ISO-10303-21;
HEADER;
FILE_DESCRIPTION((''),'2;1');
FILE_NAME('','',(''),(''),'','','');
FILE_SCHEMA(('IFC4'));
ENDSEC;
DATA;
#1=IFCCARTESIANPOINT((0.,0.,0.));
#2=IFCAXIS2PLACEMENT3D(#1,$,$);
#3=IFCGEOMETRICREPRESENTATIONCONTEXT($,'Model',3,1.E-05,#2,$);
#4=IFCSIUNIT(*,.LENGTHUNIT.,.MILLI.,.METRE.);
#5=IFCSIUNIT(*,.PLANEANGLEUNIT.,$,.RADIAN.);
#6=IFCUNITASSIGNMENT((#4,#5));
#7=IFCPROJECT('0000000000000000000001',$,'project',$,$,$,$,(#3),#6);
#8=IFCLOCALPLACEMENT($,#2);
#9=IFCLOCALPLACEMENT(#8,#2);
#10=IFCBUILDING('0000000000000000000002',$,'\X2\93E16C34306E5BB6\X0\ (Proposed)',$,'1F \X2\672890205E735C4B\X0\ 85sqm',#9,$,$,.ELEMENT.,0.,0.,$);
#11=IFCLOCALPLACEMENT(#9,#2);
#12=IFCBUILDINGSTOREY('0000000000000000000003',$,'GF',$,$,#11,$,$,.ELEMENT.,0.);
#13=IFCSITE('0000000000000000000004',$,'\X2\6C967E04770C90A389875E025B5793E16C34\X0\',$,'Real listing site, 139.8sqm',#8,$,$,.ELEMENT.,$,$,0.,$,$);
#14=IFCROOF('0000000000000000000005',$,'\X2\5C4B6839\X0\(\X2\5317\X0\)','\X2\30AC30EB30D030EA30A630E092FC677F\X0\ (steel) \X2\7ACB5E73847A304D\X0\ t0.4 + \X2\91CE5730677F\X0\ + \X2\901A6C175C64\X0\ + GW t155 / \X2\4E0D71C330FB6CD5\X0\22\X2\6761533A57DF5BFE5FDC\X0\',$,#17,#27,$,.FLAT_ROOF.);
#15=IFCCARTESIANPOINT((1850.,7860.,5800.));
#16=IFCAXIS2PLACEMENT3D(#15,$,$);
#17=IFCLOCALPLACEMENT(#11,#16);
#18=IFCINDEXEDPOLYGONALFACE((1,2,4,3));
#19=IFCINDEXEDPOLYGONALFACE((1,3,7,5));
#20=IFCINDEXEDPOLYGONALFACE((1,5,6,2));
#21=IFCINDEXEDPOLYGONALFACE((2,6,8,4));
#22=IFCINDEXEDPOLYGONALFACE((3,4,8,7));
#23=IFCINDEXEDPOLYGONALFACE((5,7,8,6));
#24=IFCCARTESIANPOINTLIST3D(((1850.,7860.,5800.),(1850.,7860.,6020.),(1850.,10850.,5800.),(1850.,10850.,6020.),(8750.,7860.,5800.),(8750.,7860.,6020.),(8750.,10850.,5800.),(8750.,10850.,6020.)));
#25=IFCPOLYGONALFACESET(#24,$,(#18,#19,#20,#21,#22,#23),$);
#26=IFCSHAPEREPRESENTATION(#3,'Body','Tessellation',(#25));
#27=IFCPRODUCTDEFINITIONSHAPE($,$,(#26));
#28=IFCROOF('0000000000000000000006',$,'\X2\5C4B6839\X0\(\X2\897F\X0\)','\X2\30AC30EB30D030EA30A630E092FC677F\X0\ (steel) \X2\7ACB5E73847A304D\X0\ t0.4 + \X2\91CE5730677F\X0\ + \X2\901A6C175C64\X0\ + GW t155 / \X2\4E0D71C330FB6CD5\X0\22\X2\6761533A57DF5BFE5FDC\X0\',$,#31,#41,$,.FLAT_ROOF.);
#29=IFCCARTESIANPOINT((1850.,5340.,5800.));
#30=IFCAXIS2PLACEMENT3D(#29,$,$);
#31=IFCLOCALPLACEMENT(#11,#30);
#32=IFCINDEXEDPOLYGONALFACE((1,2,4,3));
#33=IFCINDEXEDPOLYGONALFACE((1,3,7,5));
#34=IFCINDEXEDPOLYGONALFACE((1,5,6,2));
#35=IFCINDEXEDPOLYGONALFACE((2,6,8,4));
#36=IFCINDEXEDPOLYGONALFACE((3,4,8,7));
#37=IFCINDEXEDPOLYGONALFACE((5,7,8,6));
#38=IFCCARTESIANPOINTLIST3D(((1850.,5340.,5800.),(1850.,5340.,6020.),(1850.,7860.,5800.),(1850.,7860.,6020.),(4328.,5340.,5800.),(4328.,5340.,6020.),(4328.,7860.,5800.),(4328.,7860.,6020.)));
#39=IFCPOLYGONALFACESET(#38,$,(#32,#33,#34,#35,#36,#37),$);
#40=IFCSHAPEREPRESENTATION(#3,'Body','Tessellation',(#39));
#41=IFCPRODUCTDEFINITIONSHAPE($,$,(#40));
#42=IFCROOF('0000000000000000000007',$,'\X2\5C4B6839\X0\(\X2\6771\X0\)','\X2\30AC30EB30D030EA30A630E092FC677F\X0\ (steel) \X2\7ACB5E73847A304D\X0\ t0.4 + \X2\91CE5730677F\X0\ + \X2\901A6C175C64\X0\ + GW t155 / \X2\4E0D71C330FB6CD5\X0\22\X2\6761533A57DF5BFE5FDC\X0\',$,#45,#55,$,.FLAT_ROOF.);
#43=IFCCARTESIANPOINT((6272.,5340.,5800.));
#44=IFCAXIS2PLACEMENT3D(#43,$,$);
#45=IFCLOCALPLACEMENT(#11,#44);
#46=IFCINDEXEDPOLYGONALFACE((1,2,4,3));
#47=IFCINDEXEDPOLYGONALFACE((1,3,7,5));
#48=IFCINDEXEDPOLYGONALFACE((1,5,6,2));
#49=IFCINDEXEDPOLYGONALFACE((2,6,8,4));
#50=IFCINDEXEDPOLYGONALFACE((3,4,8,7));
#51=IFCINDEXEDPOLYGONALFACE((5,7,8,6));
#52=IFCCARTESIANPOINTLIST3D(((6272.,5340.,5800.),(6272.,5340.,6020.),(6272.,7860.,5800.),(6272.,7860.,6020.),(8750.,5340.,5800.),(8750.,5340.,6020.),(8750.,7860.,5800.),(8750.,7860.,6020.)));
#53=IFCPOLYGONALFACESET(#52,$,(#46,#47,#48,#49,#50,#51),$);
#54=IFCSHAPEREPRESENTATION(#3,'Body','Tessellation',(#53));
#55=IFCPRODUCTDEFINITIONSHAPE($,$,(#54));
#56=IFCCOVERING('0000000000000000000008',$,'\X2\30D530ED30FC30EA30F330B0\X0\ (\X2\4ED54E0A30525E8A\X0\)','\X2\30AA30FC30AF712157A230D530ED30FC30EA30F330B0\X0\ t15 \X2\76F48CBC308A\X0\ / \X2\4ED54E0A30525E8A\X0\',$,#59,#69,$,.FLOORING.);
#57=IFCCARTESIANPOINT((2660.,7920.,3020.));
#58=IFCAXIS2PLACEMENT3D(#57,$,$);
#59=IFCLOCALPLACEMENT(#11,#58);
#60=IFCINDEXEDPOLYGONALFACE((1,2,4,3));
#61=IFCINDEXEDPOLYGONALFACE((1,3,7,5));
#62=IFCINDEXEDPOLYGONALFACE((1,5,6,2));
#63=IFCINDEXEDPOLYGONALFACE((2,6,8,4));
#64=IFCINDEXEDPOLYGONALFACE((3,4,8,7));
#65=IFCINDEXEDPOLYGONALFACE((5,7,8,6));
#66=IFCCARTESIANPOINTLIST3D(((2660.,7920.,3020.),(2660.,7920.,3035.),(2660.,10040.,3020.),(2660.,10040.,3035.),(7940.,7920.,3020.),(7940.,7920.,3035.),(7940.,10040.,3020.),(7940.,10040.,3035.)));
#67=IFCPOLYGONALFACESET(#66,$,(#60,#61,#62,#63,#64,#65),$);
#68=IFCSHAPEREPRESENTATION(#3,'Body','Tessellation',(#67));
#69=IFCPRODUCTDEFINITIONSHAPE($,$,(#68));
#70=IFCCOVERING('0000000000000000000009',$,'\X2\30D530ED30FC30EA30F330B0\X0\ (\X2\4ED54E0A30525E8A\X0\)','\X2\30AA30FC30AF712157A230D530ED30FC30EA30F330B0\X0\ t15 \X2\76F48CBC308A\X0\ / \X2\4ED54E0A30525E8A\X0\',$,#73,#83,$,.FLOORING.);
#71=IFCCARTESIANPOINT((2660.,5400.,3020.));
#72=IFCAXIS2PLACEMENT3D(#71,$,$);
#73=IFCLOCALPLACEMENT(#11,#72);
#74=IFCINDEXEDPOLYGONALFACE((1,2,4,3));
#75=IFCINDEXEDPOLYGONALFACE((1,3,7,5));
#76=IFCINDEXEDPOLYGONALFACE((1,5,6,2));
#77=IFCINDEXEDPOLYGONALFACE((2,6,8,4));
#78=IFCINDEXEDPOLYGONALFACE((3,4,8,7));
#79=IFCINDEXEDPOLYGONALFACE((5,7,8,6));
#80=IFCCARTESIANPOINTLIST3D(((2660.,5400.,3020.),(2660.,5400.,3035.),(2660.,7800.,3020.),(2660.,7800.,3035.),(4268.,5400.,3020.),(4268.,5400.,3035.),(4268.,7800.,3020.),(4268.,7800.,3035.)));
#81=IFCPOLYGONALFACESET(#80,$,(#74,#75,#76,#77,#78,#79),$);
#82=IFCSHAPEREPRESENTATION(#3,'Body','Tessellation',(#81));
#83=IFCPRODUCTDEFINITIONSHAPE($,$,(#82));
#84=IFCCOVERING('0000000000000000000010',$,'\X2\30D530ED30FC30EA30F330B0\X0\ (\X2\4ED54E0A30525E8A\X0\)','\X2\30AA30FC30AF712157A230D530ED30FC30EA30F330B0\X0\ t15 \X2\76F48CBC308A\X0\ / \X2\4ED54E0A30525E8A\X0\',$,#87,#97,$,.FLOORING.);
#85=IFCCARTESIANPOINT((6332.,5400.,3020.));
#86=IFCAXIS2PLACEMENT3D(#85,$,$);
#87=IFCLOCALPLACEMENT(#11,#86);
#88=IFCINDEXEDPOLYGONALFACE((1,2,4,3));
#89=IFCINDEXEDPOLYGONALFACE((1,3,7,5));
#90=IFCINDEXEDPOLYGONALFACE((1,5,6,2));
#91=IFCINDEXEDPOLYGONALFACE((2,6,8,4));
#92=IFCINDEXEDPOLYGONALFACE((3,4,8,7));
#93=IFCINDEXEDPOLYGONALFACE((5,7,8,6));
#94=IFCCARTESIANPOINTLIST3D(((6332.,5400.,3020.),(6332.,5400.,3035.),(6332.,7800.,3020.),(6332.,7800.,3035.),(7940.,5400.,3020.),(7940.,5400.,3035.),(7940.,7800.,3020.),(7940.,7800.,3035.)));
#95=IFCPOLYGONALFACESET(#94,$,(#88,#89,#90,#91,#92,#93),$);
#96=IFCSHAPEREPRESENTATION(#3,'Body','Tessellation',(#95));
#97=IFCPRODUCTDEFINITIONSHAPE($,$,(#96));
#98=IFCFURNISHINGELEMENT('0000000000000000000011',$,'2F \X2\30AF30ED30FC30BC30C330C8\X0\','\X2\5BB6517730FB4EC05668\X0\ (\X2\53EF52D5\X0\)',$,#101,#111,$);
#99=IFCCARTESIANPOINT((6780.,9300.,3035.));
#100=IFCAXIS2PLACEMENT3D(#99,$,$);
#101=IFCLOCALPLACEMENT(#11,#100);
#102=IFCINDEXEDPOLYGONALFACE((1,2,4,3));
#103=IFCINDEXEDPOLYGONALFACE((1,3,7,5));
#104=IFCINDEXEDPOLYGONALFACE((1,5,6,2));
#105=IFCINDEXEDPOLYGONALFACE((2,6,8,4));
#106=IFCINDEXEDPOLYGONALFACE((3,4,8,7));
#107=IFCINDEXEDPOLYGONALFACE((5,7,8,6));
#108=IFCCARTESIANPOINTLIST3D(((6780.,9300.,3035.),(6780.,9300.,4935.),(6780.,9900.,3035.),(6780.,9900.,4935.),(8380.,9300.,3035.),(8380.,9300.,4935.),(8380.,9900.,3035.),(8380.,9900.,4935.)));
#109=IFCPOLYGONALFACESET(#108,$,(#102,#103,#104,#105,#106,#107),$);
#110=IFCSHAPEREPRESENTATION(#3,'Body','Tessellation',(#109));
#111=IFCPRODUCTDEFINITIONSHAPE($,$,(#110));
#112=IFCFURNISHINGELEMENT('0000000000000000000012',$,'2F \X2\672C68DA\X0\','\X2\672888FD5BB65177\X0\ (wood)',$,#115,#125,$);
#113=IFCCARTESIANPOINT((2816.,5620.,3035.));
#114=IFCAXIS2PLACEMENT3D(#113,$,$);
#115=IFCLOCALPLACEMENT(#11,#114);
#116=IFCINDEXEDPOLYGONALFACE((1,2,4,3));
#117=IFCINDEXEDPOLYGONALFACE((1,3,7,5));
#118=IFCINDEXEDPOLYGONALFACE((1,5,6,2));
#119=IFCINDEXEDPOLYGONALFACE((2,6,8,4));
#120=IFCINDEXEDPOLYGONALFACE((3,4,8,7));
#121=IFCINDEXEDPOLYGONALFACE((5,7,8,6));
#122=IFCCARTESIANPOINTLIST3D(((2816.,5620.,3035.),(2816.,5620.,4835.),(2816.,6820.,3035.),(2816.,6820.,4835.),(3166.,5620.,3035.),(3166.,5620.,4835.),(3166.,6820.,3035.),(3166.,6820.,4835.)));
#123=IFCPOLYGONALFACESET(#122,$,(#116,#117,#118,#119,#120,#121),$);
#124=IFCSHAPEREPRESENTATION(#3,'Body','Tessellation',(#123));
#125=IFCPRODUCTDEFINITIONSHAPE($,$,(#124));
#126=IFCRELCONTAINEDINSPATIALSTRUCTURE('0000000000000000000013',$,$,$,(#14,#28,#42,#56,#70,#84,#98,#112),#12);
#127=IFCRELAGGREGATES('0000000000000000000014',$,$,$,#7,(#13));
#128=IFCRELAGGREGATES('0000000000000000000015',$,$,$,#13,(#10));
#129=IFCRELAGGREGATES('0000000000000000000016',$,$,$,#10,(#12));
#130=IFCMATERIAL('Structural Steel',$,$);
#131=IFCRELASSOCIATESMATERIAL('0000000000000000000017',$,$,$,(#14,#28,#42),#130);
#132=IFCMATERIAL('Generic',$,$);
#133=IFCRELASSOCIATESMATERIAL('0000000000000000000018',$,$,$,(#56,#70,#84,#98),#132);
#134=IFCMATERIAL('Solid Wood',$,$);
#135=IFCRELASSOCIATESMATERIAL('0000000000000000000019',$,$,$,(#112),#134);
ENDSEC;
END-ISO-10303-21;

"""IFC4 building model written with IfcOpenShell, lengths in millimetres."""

from ifc_helpers import new_model, si_unit, frame, frame_2d, origin, place, context, project, spatial, rectangle, extrude, material, element, save


model = new_model("IFC4")

# Units and contexts
model_context = context("Model", 3, precision=1e-05, world=origin())
ifc_project = project(units=[si_unit("LENGTHUNIT", "METRE", prefix="MILLI"), si_unit("PLANEANGLEUNIT", "RADIAN")], contexts=[model_context])

# Site, building, storey
site_placement = place(None, origin())
site = spatial("IfcSite", under=ifc_project, at=site_placement, Name="沖縄県那覇市字鏡水", ObjectType="Real listing site, 139.8sqm", CompositionType="ELEMENT", RefElevation=0.0)
building_placement = place(site_placement, origin())
building = spatial("IfcBuilding", under=site, at=building_placement, Name="鏡水の家 (Proposed)", ObjectType="1F 木造平屋 85sqm", CompositionType="ELEMENT", ElevationOfRefHeight=0.0, ElevationOfTerrain=0.0)
storey_placement = place(building_placement, origin())
storey = spatial("IfcBuildingStorey", under=building, at=storey_placement, Name="GF", CompositionType="ELEMENT", Elevation=0.0)

# Shared definitions
ifc_material_1 = material(Name="Solid Wood")

# Shared definitions
ifc_material_2 = material(Name="Generic")

# Roofs
ifc_material_3 = material(Name="Structural Steel")
for number, where, name in (
    (1, (1850.0, 7860.0, 5800.0), "屋根(北)"),
):
    element("IfcRoof", number, at=place(storey_placement, frame(where)), inside=storey, material=ifc_material_3, Name=name, Description="ガルバリウム鋼板 (steel) 立平葺き t0.4 + 野地板 + 通気層 + GW t155 / 不燃・法22条区域対応", PredefinedType="FLAT_ROOF", context=model_context, shape_type="SweptSolid", body=[
        extrude(rectangle(XDim=6900.0, YDim=2990.0, at=frame_2d((3450.0, 1495.0))), frame((1850.0, 7860.0, 5800.0)), (0.0, 0.0, 1.0), 220.0),
    ])
roof_1_placement = place(storey_placement, frame((1850.0, 5340.0, 5800.0)))
element("IfcRoof", 2, at=roof_1_placement, inside=storey, material=ifc_material_3, Name="屋根(西)", Description="ガルバリウム鋼板 (steel) 立平葺き t0.4 + 野地板 + 通気層 + GW t155 / 不燃・法22条区域対応", PredefinedType="FLAT_ROOF", context=model_context, shape_type="SweptSolid", body=[
    extrude(rectangle(XDim=2478.0, YDim=2520.0, at=frame_2d((1239.0, 1260.0))), frame((1850.0, 5340.0, 5800.0)), (0.0, 0.0, 1.0), 220.0),
])
roof_2_placement = place(storey_placement, frame((6272.0, 5340.0, 5800.0)))
element("IfcRoof", 3, at=roof_2_placement, inside=storey, material=ifc_material_3, Name="屋根(東)", Description="ガルバリウム鋼板 (steel) 立平葺き t0.4 + 野地板 + 通気層 + GW t155 / 不燃・法22条区域対応", PredefinedType="FLAT_ROOF", context=model_context, shape_type="SweptSolid", body=[
    extrude(rectangle(XDim=2478.0, YDim=2520.0, at=frame_2d((1239.0, 1260.0))), frame((6272.0, 5340.0, 5800.0)), (0.0, 0.0, 1.0), 220.0),
])

# Coverings
covering_1_placement = place(storey_placement, frame((2660.0, 7920.0, 3020.0)))
element("IfcCovering", 4, at=covering_1_placement, inside=storey, material=ifc_material_2, Name="フローリング (仕上げ床)", Description="オーク無垢フローリング t15 直貼り / 仕上げ床", PredefinedType="FLOORING", context=model_context, shape_type="SweptSolid", body=[
    extrude(rectangle(XDim=5280.0, YDim=2120.0, at=frame_2d((2640.0, 1060.0))), frame((2660.0, 7920.0, 3020.0)), (0.0, 0.0, 1.0), 15.0),
])
covering_2_placement = place(storey_placement, frame((2660.0, 5400.0, 3020.0)))
element("IfcCovering", 5, at=covering_2_placement, inside=storey, material=ifc_material_2, Name="フローリング (仕上げ床)", Description="オーク無垢フローリング t15 直貼り / 仕上げ床", PredefinedType="FLOORING", context=model_context, shape_type="SweptSolid", body=[
    extrude(rectangle(XDim=1608.0, YDim=2400.0, at=frame_2d((804.0, 1200.0))), frame((2660.0, 5400.0, 3020.0)), (0.0, 0.0, 1.0), 15.0),
])
covering_3_placement = place(storey_placement, frame((6332.0, 5400.0, 3020.0)))
element("IfcCovering", 6, at=covering_3_placement, inside=storey, material=ifc_material_2, Name="フローリング (仕上げ床)", Description="オーク無垢フローリング t15 直貼り / 仕上げ床", PredefinedType="FLOORING", context=model_context, shape_type="SweptSolid", body=[
    extrude(rectangle(XDim=1608.0, YDim=2400.0, at=frame_2d((804.0, 1200.0))), frame((6332.0, 5400.0, 3020.0)), (0.0, 0.0, 1.0), 15.0),
])

# Furnishing elements
furnishing_1_placement = place(storey_placement, frame((6780.0, 9300.0, 3035.0)))
element("IfcFurnishingElement", 7, at=furnishing_1_placement, inside=storey, material=ifc_material_2, Name="2F クローゼット", Description="家具・什器 (可動)", context=model_context, shape_type="SweptSolid", body=[
    extrude(rectangle(XDim=1600.0, YDim=600.0, at=frame_2d((800.0, 300.0))), frame((6780.0, 9300.0, 3035.0)), (0.0, 0.0, 1.0), 1900.0),
])
furnishing_2_placement = place(storey_placement, frame((2816.0, 5620.0, 3035.0)))
element("IfcFurnishingElement", 8, at=furnishing_2_placement, inside=storey, material=ifc_material_1, Name="2F 本棚", Description="木製家具 (wood)", context=model_context, shape_type="SweptSolid", body=[
    extrude(rectangle(XDim=350.0, YDim=1200.0, at=frame_2d((175.0, 600.0))), frame((2816.0, 5620.0, 3035.0)), (0.0, 0.0, 1.0), 1800.0),
])

save(model, "model.ifc")
